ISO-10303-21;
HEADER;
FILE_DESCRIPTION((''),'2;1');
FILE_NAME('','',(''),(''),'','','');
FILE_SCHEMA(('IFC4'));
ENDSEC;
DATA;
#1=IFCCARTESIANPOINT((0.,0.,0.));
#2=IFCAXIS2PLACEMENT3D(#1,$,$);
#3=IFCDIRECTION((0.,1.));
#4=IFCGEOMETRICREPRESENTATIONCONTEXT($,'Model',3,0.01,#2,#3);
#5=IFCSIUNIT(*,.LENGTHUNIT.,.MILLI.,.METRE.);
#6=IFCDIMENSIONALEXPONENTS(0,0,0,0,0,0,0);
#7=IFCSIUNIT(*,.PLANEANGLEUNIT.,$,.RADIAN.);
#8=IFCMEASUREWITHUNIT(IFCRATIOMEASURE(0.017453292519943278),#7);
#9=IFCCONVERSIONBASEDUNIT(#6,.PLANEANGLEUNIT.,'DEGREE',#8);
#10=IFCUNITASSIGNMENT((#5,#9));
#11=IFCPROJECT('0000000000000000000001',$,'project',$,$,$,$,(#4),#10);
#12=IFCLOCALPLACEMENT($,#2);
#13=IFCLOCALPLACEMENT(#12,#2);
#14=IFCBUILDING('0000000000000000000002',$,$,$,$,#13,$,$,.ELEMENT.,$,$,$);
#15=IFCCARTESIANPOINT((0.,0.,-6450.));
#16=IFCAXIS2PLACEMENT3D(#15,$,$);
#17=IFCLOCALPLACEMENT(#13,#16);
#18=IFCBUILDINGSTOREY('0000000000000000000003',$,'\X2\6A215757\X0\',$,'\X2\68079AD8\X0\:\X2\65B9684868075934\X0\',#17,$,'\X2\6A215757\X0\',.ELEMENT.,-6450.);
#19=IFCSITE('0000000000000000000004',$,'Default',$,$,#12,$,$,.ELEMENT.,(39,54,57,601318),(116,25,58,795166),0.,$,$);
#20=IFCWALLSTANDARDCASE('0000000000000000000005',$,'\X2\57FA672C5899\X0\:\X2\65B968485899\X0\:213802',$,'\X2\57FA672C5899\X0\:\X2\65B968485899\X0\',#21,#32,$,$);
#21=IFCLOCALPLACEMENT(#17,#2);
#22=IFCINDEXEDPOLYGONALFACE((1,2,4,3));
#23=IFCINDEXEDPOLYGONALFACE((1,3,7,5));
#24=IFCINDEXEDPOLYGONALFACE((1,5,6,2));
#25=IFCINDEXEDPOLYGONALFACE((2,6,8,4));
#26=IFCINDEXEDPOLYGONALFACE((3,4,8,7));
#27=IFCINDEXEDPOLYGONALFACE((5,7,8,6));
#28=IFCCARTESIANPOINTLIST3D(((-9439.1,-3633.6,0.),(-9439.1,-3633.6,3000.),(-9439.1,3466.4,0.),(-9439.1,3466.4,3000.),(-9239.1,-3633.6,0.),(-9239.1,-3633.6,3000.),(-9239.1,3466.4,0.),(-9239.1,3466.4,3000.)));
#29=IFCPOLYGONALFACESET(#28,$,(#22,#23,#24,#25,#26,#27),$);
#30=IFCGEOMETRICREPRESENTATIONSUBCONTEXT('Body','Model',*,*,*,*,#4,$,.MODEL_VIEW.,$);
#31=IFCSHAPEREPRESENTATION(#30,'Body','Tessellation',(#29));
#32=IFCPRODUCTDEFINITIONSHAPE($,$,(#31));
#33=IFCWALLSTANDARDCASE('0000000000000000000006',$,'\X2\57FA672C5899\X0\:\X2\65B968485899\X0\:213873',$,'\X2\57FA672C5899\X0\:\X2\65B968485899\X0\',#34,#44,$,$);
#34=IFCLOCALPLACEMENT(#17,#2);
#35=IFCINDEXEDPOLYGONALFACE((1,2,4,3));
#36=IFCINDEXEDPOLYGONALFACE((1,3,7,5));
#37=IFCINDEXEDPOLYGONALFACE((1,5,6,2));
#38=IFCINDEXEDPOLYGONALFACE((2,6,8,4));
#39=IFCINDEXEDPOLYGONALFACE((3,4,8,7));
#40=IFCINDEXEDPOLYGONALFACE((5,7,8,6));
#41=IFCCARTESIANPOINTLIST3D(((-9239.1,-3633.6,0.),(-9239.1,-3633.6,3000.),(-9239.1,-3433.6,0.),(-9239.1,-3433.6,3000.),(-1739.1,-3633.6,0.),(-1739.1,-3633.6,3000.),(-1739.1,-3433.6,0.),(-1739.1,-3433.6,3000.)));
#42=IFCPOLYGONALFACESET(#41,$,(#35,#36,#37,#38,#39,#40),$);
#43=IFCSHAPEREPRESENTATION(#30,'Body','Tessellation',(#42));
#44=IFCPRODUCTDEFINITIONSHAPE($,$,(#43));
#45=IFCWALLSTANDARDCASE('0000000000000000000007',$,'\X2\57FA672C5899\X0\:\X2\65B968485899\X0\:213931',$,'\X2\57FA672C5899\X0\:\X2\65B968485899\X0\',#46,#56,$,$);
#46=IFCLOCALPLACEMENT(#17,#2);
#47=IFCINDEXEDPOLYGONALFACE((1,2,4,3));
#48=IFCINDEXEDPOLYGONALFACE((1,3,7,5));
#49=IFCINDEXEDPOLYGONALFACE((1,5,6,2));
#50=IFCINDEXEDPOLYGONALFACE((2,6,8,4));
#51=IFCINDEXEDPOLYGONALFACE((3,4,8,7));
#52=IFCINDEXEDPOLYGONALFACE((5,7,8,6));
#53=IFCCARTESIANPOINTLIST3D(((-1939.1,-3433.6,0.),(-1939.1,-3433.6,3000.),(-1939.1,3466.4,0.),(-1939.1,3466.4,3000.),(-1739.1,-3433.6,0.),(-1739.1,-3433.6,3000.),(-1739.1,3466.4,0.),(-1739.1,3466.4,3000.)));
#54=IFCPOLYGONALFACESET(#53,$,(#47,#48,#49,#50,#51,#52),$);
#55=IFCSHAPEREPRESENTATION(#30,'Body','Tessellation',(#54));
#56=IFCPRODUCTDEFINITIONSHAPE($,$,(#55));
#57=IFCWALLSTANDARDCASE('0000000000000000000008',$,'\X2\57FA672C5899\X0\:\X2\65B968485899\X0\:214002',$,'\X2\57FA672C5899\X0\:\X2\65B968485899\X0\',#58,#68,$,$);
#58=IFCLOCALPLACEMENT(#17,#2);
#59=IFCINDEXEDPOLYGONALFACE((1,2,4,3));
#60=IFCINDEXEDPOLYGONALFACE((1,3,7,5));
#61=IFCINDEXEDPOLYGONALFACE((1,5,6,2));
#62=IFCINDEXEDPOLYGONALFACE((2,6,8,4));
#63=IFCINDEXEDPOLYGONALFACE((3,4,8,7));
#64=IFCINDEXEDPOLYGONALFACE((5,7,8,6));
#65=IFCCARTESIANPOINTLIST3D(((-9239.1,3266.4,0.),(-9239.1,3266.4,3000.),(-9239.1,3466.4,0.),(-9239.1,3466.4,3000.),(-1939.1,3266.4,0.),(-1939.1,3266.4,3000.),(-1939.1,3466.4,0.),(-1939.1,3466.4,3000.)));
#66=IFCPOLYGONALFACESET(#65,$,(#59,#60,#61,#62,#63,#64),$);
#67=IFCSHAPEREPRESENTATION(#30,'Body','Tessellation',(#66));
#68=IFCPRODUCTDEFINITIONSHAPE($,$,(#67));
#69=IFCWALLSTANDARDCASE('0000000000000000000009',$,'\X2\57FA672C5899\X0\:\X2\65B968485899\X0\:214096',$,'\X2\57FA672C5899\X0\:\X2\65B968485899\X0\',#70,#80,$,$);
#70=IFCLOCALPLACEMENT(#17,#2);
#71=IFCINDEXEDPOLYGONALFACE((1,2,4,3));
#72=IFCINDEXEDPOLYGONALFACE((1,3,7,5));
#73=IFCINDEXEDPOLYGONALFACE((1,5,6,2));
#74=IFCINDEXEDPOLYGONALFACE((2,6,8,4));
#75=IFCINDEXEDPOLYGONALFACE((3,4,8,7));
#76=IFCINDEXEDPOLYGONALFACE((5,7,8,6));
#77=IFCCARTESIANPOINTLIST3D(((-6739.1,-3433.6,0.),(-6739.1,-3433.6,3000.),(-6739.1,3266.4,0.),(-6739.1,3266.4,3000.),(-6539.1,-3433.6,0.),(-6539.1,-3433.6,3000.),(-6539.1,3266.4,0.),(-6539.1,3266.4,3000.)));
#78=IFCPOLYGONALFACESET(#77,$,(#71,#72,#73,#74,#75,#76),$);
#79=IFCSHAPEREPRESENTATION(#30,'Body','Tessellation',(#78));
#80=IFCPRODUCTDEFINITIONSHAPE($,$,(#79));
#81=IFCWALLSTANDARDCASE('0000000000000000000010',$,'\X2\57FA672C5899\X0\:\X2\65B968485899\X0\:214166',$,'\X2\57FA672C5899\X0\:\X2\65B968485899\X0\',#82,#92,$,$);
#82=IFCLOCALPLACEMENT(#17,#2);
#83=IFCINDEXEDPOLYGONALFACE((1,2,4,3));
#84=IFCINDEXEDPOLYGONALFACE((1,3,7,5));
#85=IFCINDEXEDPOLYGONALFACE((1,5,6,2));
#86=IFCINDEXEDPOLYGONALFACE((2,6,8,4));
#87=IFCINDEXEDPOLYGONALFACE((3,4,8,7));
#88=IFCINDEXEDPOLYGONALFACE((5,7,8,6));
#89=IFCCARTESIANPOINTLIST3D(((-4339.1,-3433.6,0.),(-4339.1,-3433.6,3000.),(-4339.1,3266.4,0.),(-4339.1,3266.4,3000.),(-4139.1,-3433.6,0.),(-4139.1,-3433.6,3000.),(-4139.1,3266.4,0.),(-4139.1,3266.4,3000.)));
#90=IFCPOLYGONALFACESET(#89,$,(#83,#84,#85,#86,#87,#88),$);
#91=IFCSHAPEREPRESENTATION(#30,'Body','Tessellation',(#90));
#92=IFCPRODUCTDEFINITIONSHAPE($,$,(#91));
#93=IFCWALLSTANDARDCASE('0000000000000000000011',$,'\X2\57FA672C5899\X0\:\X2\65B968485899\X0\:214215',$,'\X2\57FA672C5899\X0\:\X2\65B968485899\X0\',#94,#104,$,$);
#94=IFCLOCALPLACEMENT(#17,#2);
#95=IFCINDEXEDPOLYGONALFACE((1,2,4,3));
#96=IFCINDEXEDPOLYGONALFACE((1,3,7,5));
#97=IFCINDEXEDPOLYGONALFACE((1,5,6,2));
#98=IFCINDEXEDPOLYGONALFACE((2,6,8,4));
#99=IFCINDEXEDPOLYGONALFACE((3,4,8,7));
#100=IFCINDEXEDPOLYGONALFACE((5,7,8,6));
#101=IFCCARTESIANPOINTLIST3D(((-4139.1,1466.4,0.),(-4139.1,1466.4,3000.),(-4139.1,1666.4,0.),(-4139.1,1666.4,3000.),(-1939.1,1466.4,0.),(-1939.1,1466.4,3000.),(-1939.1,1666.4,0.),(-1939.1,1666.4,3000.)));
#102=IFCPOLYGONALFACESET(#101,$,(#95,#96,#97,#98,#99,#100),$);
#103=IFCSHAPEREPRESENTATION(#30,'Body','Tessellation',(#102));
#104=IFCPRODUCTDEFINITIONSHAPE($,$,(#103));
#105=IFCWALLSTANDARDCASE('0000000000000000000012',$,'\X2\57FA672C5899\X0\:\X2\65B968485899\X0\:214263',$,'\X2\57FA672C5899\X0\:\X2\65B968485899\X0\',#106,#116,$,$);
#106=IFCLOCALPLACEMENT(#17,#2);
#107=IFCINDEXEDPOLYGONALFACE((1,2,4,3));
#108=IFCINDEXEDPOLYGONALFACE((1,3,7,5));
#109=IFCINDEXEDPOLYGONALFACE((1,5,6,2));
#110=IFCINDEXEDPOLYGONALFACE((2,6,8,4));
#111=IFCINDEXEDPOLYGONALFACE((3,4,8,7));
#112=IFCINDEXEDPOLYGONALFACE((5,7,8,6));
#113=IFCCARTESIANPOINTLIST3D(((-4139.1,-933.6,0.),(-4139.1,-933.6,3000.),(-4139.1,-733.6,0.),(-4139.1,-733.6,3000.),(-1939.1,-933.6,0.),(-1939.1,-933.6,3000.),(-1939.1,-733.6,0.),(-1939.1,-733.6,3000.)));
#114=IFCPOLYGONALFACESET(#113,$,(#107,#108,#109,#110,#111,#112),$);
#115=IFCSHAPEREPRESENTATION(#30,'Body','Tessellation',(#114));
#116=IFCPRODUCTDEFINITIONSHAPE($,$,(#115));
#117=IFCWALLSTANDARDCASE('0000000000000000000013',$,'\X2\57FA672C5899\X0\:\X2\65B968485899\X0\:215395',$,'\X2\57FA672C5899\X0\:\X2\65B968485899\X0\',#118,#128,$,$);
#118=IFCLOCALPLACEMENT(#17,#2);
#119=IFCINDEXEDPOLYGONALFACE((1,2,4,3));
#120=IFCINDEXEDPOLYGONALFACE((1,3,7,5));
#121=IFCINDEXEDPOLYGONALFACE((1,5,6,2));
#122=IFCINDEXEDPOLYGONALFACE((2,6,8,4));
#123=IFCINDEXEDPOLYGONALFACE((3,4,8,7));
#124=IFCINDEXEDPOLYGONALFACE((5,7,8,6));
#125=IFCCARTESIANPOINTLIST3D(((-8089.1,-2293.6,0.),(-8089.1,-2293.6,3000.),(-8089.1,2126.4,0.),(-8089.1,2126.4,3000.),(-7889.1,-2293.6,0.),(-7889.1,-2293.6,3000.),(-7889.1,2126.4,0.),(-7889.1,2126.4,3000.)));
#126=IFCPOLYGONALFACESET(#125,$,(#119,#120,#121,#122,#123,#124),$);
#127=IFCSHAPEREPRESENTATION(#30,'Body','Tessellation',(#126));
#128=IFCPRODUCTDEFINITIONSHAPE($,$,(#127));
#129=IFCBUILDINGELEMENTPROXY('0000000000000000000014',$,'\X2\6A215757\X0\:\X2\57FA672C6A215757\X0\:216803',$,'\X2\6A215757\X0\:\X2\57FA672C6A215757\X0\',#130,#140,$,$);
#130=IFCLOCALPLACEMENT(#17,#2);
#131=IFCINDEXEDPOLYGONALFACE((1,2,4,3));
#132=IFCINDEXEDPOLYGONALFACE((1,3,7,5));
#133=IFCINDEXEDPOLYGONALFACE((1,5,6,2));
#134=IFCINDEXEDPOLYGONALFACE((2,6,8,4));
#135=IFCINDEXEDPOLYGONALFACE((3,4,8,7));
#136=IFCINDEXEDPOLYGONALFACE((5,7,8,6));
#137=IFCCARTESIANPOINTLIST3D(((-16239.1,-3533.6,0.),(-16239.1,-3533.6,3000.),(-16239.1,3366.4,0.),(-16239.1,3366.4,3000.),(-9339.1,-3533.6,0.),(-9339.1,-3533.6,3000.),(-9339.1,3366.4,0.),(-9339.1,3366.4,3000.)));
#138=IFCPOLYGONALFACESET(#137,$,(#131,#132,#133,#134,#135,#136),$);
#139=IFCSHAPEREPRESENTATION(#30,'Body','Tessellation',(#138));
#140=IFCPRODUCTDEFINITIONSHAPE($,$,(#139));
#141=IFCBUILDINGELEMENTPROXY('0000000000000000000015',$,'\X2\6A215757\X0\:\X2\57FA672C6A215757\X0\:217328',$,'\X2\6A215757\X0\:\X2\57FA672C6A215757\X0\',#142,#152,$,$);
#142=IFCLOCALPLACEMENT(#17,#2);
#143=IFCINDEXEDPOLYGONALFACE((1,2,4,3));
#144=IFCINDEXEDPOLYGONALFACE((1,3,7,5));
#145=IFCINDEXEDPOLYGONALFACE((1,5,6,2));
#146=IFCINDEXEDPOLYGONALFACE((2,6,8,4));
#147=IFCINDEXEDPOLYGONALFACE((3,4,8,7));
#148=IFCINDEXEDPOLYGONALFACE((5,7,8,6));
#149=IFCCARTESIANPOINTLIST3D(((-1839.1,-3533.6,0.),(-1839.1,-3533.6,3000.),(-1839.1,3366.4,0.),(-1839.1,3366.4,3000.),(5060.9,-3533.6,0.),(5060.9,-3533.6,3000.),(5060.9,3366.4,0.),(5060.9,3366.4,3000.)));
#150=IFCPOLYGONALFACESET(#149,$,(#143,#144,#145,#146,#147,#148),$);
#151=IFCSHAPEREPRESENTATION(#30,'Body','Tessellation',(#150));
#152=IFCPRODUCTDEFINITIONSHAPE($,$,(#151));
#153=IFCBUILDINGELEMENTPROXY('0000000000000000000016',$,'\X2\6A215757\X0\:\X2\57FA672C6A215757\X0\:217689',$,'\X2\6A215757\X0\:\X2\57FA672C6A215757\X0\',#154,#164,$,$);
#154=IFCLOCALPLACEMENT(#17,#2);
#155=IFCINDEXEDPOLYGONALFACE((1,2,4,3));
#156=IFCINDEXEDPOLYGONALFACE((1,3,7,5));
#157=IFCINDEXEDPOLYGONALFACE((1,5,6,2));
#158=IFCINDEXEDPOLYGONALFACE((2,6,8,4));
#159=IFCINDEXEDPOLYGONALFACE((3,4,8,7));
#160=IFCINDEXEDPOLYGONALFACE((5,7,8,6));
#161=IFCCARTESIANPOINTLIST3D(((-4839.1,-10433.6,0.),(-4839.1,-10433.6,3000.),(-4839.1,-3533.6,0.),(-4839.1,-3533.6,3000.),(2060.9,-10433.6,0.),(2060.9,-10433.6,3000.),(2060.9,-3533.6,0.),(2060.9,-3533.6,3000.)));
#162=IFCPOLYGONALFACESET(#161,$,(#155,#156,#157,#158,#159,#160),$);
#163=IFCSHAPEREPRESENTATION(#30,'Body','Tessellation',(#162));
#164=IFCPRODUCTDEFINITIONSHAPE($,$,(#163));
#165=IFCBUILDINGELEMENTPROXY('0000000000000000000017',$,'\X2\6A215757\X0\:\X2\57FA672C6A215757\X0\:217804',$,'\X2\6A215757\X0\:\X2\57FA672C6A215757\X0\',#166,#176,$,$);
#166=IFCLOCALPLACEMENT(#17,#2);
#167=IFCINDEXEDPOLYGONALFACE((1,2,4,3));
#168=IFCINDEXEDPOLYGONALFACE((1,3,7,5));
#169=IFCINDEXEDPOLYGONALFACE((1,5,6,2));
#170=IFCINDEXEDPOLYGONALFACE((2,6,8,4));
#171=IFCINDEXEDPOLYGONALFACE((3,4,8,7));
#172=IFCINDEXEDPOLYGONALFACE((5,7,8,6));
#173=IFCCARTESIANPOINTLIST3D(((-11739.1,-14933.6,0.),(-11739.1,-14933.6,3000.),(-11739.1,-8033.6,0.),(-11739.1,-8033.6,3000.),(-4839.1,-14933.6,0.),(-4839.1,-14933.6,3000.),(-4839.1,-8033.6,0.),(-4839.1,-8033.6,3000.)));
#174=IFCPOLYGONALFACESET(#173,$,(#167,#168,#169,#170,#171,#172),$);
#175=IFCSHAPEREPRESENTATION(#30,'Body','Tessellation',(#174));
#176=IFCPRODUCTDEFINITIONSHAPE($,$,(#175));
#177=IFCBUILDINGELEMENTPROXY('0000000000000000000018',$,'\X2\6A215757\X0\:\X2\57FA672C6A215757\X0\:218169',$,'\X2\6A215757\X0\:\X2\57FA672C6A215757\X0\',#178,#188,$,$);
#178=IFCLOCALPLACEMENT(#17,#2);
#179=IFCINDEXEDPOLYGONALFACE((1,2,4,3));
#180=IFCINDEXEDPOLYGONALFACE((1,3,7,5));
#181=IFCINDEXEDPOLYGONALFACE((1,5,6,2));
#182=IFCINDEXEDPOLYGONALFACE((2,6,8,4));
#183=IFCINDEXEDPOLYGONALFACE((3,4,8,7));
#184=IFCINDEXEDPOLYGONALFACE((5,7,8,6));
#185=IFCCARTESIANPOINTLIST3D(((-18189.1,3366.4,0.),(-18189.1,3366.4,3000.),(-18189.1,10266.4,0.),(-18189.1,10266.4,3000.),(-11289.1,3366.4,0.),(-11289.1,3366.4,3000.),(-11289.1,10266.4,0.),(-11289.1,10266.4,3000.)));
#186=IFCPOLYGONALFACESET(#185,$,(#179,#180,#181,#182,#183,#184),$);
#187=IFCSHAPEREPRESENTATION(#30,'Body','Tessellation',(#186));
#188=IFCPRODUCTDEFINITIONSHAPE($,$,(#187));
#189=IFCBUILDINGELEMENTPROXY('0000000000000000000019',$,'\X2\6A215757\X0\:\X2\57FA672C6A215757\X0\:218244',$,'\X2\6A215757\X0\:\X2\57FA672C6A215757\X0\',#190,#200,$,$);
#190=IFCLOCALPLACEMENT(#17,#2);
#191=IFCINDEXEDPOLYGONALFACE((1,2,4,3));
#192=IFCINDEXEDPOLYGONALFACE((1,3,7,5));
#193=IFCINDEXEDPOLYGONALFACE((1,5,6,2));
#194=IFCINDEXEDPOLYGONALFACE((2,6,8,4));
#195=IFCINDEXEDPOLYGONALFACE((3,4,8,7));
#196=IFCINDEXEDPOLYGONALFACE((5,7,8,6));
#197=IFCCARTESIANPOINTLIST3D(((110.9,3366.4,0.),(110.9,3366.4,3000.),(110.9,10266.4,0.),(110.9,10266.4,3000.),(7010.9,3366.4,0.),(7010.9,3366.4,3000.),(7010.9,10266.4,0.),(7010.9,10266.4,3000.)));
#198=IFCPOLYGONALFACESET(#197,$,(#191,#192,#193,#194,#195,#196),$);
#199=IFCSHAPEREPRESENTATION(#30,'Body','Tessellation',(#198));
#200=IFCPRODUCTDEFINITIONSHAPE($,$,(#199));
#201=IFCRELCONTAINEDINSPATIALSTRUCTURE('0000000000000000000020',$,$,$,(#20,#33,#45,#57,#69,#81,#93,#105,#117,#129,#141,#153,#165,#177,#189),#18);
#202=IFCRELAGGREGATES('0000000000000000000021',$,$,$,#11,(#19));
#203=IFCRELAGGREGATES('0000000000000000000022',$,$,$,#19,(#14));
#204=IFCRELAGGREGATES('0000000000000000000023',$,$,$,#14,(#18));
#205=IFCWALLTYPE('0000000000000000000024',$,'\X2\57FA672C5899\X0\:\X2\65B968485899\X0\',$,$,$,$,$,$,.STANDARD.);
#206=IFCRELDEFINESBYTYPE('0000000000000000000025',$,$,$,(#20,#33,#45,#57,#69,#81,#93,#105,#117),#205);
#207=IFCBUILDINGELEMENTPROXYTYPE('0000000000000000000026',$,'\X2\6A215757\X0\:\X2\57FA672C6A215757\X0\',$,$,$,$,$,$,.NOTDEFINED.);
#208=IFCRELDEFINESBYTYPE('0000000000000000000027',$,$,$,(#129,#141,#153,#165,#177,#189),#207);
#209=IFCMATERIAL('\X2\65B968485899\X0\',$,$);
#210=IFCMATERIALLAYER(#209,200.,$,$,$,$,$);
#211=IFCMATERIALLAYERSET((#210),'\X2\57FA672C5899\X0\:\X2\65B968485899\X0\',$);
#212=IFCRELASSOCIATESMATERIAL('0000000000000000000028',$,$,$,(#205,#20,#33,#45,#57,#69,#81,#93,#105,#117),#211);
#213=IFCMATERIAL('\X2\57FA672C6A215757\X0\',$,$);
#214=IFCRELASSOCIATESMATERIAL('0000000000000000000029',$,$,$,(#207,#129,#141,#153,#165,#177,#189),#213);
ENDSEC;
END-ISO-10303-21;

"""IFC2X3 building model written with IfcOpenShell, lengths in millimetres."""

from ifc_helpers import new_model, entity, si_unit, converted_unit, direction, frame, frame_2d, origin, origin_2d_with_axis, place, context, subcontext, project, spatial, rectangle, extrude, source, transform, mapped, material, layer, layer_set, layer_usage, type_object, type_shapes, element, save


model = new_model("IFC2X3")

# Units and contexts
model_context = context("Model", 3, precision=0.01, world=origin(), true_north=direction((0.0, 1.0)))
body_context = subcontext(model_context, "Body", "Model", "MODEL_VIEW")
ifc_project = project(units=[si_unit("LENGTHUNIT", "METRE", prefix="MILLI"), converted_unit("PLANEANGLEUNIT", "DEGREE", entity("IfcRatioMeasure", 0.017453292519943278), si_unit("PLANEANGLEUNIT", "RADIAN"), dimensions=[0, 0, 0, 0, 0, 0, 0])], contexts=[model_context])

# Site, building, storey
site_placement = place(None, origin())
site = spatial("IfcSite", under=ifc_project, at=site_placement, Name="Default", CompositionType="ELEMENT", RefLatitude=(39, 54, 57, 601318), RefLongitude=(116, 25, 58, 795166), RefElevation=0.0)
building_placement = place(site_placement, origin())
building = spatial("IfcBuilding", under=site, at=building_placement, CompositionType="ELEMENT")
storey_placement = place(building_placement, frame((0.0, 0.0, -6450.0)))
storey = spatial("IfcBuildingStorey", under=building, at=storey_placement, Name="模块", ObjectType="标高:方案标头", LongName="模块", CompositionType="ELEMENT", Elevation=-6450.0)

# Walls
ifc_material_1 = material(Name="方案墙")
ifc_layer = layer(ifc_material_1, 200.0)
ifc_layer_set = layer_set([ifc_layer], Name="基本墙:方案墙")
ifc_layer_usage_1 = layer_usage(ifc_layer_set, "AXIS2", "NEGATIVE", 100.0)
wall_type = type_object("IfcWallType", Name="基本墙:方案墙", PredefinedType="STANDARD", material=ifc_layer_set)
wall_1_placement = place(storey_placement, frame((-9339.1, 3466.4, 0.0), z_axis=(0.0, 0.0, 1.0), x_axis=(0.0, -1.0, 0.0)))
element("IfcWallStandardCase", 1, at=wall_1_placement, inside=storey, type_object=wall_type, material=ifc_layer_usage_1, Name="基本墙:方案墙:213802", ObjectType="基本墙:方案墙", context=body_context, shape_type="SweptSolid", body=[
    extrude(rectangle(XDim=7100.0, YDim=200.0, at=frame_2d((3550.0, 0.0), x_axis=(-1.0, 0.0))), origin(), (0.0, 0.0, 1.0), 3000.0),
])
ifc_layer_usage_2 = layer_usage(ifc_layer_set, "AXIS2", "NEGATIVE", 100.0)
wall_2_placement = place(storey_placement, frame((-9239.1, -3533.6, 0.0)))
element("IfcWallStandardCase", 2, at=wall_2_placement, inside=storey, type_object=wall_type, material=ifc_layer_usage_2, Name="基本墙:方案墙:213873", ObjectType="基本墙:方案墙", context=body_context, shape_type="SweptSolid", body=[
    extrude(rectangle(XDim=7500.0, YDim=200.0, at=frame_2d((3750.0, 0.0), x_axis=(-1.0, 0.0))), origin(), (0.0, 0.0, 1.0), 3000.0),
])
ifc_layer_usage_3 = layer_usage(ifc_layer_set, "AXIS2", "NEGATIVE", 100.0)
wall_3_placement = place(storey_placement, frame((-1839.1, -3433.6, 0.0), z_axis=(0.0, 0.0, 1.0), x_axis=(0.0, 1.0, 0.0)))
element("IfcWallStandardCase", 3, at=wall_3_placement, inside=storey, type_object=wall_type, material=ifc_layer_usage_3, Name="基本墙:方案墙:213931", ObjectType="基本墙:方案墙", context=body_context, shape_type="SweptSolid", body=[
    extrude(rectangle(XDim=6900.0, YDim=200.0, at=frame_2d((3450.0, 0.0), x_axis=(-1.0, 0.0))), origin(), (0.0, 0.0, 1.0), 3000.0),
])
ifc_layer_usage_4 = layer_usage(ifc_layer_set, "AXIS2", "NEGATIVE", 100.0)
wall_4_placement = place(storey_placement, frame((-1939.1, 3366.4, 0.0), z_axis=(0.0, 0.0, 1.0), x_axis=(-1.0, 0.0, 0.0)))
element("IfcWallStandardCase", 4, at=wall_4_placement, inside=storey, type_object=wall_type, material=ifc_layer_usage_4, Name="基本墙:方案墙:214002", ObjectType="基本墙:方案墙", context=body_context, shape_type="SweptSolid", body=[
    extrude(rectangle(XDim=7300.0, YDim=200.0, at=frame_2d((3650.0, 0.0), x_axis=(-1.0, 0.0))), origin(), (0.0, 0.0, 1.0), 3000.0),
])
ifc_layer_usage_5 = layer_usage(ifc_layer_set, "AXIS2", "NEGATIVE", 100.0)
wall_5_placement = place(storey_placement, frame((-6639.1, 3266.4, 0.0), z_axis=(0.0, 0.0, 1.0), x_axis=(0.0, -1.0, 0.0)))
element("IfcWallStandardCase", 5, at=wall_5_placement, inside=storey, type_object=wall_type, material=ifc_layer_usage_5, Name="基本墙:方案墙:214096", ObjectType="基本墙:方案墙", context=body_context, shape_type="SweptSolid", body=[
    extrude(rectangle(XDim=6700.0, YDim=200.0, at=frame_2d((3350.0, 0.0), x_axis=(-1.0, 0.0))), origin(), (0.0, 0.0, 1.0), 3000.0),
])
ifc_layer_usage_6 = layer_usage(ifc_layer_set, "AXIS2", "NEGATIVE", 100.0)
wall_6_placement = place(storey_placement, frame((-4239.1, 3266.4, 0.0), z_axis=(0.0, 0.0, 1.0), x_axis=(0.0, -1.0, 0.0)))
element("IfcWallStandardCase", 6, at=wall_6_placement, inside=storey, type_object=wall_type, material=ifc_layer_usage_6, Name="基本墙:方案墙:214166", ObjectType="基本墙:方案墙", context=body_context, shape_type="SweptSolid", body=[
    extrude(rectangle(XDim=6700.0, YDim=200.0, at=frame_2d((3350.0, 0.0), x_axis=(-1.0, 0.0))), origin(), (0.0, 0.0, 1.0), 3000.0),
])
ifc_layer_usage_7 = layer_usage(ifc_layer_set, "AXIS2", "NEGATIVE", 100.0)
wall_7_placement = place(storey_placement, frame((-4139.1, 1566.4, 0.0)))
element("IfcWallStandardCase", 7, at=wall_7_placement, inside=storey, type_object=wall_type, material=ifc_layer_usage_7, Name="基本墙:方案墙:214215", ObjectType="基本墙:方案墙", context=body_context, shape_type="SweptSolid", body=[
    extrude(rectangle(XDim=2200.0, YDim=200.0, at=frame_2d((1100.0, 0.0), x_axis=(-1.0, 0.0))), origin(), (0.0, 0.0, 1.0), 3000.0),
])
ifc_layer_usage_8 = layer_usage(ifc_layer_set, "AXIS2", "NEGATIVE", 100.0)
wall_8_placement = place(storey_placement, frame((-4139.1, -833.6, 0.0)))
element("IfcWallStandardCase", 8, at=wall_8_placement, inside=storey, type_object=wall_type, material=ifc_layer_usage_8, Name="基本墙:方案墙:214263", ObjectType="基本墙:方案墙", context=body_context, shape_type="SweptSolid", body=[
    extrude(rectangle(XDim=2200.0, YDim=200.0, at=frame_2d((1100.0, 0.0), x_axis=(-1.0, 0.0))), origin(), (0.0, 0.0, 1.0), 3000.0),
])
ifc_layer_usage_9 = layer_usage(ifc_layer_set, "AXIS2", "NEGATIVE", 100.0)
wall_9_placement = place(storey_placement, frame((-7989.1, 2126.4, 0.0), z_axis=(0.0, 0.0, 1.0), x_axis=(0.0, -1.0, 0.0)))
element("IfcWallStandardCase", 9, at=wall_9_placement, inside=storey, type_object=wall_type, material=ifc_layer_usage_9, Name="基本墙:方案墙:215395", ObjectType="基本墙:方案墙", context=body_context, shape_type="SweptSolid", body=[
    extrude(rectangle(XDim=4420.0, YDim=200.0, at=frame_2d((2210.0, 0.0), x_axis=(-1.0, 0.0))), origin(), (0.0, 0.0, 1.0), 3000.0),
])

# Building element proxies
ifc_material_2 = material(Name="基本模块")
building_element_proxy_type_1 = type_object("IfcBuildingElementProxyType", Name="模块:基本模块", PredefinedType="NOTDEFINED", material=ifc_material_2)
shared_shape_1 = source(origin(), body_context, "Body", "SweptSolid", [
    extrude(rectangle(XDim=6900.0, YDim=6900.0, at=origin_2d_with_axis()), frame((0.0, 0.0, 0.0), z_axis=(0.0, 0.0, 1.0), x_axis=(-1.0, 0.0, 0.0)), (0.0, 0.0, 1.0), 3000.0),
])
type_shapes(building_element_proxy_type_1, [shared_shape_1])
for number, where, name in (
    (10, (-12789.1, -83.6, 0.0), "模块:基本模块:216803"),
    (11, (1610.9, -83.6, 0.0), "模块:基本模块:217328"),
    (12, (-1389.1, -6983.6, 0.0), "模块:基本模块:217689"),
    (13, (-8289.1, -11483.6, 0.0), "模块:基本模块:217804"),
    (14, (-14739.1, 6816.4, 0.0), "模块:基本模块:218169"),
    (15, (3560.9, 6816.4, 0.0), "模块:基本模块:218244"),
):
    element("IfcBuildingElementProxy", number, at=place(storey_placement, frame(where)), inside=storey, type_object=building_element_proxy_type_1, material=ifc_material_2, Name=name, ObjectType="模块:基本模块", context=body_context, shape_type="MappedRepresentation", body=[
        mapped(shared_shape_1, transform((0.0, 0.0, 0.0), scale=1.0)),
    ])

save(model, "model.ifc")
